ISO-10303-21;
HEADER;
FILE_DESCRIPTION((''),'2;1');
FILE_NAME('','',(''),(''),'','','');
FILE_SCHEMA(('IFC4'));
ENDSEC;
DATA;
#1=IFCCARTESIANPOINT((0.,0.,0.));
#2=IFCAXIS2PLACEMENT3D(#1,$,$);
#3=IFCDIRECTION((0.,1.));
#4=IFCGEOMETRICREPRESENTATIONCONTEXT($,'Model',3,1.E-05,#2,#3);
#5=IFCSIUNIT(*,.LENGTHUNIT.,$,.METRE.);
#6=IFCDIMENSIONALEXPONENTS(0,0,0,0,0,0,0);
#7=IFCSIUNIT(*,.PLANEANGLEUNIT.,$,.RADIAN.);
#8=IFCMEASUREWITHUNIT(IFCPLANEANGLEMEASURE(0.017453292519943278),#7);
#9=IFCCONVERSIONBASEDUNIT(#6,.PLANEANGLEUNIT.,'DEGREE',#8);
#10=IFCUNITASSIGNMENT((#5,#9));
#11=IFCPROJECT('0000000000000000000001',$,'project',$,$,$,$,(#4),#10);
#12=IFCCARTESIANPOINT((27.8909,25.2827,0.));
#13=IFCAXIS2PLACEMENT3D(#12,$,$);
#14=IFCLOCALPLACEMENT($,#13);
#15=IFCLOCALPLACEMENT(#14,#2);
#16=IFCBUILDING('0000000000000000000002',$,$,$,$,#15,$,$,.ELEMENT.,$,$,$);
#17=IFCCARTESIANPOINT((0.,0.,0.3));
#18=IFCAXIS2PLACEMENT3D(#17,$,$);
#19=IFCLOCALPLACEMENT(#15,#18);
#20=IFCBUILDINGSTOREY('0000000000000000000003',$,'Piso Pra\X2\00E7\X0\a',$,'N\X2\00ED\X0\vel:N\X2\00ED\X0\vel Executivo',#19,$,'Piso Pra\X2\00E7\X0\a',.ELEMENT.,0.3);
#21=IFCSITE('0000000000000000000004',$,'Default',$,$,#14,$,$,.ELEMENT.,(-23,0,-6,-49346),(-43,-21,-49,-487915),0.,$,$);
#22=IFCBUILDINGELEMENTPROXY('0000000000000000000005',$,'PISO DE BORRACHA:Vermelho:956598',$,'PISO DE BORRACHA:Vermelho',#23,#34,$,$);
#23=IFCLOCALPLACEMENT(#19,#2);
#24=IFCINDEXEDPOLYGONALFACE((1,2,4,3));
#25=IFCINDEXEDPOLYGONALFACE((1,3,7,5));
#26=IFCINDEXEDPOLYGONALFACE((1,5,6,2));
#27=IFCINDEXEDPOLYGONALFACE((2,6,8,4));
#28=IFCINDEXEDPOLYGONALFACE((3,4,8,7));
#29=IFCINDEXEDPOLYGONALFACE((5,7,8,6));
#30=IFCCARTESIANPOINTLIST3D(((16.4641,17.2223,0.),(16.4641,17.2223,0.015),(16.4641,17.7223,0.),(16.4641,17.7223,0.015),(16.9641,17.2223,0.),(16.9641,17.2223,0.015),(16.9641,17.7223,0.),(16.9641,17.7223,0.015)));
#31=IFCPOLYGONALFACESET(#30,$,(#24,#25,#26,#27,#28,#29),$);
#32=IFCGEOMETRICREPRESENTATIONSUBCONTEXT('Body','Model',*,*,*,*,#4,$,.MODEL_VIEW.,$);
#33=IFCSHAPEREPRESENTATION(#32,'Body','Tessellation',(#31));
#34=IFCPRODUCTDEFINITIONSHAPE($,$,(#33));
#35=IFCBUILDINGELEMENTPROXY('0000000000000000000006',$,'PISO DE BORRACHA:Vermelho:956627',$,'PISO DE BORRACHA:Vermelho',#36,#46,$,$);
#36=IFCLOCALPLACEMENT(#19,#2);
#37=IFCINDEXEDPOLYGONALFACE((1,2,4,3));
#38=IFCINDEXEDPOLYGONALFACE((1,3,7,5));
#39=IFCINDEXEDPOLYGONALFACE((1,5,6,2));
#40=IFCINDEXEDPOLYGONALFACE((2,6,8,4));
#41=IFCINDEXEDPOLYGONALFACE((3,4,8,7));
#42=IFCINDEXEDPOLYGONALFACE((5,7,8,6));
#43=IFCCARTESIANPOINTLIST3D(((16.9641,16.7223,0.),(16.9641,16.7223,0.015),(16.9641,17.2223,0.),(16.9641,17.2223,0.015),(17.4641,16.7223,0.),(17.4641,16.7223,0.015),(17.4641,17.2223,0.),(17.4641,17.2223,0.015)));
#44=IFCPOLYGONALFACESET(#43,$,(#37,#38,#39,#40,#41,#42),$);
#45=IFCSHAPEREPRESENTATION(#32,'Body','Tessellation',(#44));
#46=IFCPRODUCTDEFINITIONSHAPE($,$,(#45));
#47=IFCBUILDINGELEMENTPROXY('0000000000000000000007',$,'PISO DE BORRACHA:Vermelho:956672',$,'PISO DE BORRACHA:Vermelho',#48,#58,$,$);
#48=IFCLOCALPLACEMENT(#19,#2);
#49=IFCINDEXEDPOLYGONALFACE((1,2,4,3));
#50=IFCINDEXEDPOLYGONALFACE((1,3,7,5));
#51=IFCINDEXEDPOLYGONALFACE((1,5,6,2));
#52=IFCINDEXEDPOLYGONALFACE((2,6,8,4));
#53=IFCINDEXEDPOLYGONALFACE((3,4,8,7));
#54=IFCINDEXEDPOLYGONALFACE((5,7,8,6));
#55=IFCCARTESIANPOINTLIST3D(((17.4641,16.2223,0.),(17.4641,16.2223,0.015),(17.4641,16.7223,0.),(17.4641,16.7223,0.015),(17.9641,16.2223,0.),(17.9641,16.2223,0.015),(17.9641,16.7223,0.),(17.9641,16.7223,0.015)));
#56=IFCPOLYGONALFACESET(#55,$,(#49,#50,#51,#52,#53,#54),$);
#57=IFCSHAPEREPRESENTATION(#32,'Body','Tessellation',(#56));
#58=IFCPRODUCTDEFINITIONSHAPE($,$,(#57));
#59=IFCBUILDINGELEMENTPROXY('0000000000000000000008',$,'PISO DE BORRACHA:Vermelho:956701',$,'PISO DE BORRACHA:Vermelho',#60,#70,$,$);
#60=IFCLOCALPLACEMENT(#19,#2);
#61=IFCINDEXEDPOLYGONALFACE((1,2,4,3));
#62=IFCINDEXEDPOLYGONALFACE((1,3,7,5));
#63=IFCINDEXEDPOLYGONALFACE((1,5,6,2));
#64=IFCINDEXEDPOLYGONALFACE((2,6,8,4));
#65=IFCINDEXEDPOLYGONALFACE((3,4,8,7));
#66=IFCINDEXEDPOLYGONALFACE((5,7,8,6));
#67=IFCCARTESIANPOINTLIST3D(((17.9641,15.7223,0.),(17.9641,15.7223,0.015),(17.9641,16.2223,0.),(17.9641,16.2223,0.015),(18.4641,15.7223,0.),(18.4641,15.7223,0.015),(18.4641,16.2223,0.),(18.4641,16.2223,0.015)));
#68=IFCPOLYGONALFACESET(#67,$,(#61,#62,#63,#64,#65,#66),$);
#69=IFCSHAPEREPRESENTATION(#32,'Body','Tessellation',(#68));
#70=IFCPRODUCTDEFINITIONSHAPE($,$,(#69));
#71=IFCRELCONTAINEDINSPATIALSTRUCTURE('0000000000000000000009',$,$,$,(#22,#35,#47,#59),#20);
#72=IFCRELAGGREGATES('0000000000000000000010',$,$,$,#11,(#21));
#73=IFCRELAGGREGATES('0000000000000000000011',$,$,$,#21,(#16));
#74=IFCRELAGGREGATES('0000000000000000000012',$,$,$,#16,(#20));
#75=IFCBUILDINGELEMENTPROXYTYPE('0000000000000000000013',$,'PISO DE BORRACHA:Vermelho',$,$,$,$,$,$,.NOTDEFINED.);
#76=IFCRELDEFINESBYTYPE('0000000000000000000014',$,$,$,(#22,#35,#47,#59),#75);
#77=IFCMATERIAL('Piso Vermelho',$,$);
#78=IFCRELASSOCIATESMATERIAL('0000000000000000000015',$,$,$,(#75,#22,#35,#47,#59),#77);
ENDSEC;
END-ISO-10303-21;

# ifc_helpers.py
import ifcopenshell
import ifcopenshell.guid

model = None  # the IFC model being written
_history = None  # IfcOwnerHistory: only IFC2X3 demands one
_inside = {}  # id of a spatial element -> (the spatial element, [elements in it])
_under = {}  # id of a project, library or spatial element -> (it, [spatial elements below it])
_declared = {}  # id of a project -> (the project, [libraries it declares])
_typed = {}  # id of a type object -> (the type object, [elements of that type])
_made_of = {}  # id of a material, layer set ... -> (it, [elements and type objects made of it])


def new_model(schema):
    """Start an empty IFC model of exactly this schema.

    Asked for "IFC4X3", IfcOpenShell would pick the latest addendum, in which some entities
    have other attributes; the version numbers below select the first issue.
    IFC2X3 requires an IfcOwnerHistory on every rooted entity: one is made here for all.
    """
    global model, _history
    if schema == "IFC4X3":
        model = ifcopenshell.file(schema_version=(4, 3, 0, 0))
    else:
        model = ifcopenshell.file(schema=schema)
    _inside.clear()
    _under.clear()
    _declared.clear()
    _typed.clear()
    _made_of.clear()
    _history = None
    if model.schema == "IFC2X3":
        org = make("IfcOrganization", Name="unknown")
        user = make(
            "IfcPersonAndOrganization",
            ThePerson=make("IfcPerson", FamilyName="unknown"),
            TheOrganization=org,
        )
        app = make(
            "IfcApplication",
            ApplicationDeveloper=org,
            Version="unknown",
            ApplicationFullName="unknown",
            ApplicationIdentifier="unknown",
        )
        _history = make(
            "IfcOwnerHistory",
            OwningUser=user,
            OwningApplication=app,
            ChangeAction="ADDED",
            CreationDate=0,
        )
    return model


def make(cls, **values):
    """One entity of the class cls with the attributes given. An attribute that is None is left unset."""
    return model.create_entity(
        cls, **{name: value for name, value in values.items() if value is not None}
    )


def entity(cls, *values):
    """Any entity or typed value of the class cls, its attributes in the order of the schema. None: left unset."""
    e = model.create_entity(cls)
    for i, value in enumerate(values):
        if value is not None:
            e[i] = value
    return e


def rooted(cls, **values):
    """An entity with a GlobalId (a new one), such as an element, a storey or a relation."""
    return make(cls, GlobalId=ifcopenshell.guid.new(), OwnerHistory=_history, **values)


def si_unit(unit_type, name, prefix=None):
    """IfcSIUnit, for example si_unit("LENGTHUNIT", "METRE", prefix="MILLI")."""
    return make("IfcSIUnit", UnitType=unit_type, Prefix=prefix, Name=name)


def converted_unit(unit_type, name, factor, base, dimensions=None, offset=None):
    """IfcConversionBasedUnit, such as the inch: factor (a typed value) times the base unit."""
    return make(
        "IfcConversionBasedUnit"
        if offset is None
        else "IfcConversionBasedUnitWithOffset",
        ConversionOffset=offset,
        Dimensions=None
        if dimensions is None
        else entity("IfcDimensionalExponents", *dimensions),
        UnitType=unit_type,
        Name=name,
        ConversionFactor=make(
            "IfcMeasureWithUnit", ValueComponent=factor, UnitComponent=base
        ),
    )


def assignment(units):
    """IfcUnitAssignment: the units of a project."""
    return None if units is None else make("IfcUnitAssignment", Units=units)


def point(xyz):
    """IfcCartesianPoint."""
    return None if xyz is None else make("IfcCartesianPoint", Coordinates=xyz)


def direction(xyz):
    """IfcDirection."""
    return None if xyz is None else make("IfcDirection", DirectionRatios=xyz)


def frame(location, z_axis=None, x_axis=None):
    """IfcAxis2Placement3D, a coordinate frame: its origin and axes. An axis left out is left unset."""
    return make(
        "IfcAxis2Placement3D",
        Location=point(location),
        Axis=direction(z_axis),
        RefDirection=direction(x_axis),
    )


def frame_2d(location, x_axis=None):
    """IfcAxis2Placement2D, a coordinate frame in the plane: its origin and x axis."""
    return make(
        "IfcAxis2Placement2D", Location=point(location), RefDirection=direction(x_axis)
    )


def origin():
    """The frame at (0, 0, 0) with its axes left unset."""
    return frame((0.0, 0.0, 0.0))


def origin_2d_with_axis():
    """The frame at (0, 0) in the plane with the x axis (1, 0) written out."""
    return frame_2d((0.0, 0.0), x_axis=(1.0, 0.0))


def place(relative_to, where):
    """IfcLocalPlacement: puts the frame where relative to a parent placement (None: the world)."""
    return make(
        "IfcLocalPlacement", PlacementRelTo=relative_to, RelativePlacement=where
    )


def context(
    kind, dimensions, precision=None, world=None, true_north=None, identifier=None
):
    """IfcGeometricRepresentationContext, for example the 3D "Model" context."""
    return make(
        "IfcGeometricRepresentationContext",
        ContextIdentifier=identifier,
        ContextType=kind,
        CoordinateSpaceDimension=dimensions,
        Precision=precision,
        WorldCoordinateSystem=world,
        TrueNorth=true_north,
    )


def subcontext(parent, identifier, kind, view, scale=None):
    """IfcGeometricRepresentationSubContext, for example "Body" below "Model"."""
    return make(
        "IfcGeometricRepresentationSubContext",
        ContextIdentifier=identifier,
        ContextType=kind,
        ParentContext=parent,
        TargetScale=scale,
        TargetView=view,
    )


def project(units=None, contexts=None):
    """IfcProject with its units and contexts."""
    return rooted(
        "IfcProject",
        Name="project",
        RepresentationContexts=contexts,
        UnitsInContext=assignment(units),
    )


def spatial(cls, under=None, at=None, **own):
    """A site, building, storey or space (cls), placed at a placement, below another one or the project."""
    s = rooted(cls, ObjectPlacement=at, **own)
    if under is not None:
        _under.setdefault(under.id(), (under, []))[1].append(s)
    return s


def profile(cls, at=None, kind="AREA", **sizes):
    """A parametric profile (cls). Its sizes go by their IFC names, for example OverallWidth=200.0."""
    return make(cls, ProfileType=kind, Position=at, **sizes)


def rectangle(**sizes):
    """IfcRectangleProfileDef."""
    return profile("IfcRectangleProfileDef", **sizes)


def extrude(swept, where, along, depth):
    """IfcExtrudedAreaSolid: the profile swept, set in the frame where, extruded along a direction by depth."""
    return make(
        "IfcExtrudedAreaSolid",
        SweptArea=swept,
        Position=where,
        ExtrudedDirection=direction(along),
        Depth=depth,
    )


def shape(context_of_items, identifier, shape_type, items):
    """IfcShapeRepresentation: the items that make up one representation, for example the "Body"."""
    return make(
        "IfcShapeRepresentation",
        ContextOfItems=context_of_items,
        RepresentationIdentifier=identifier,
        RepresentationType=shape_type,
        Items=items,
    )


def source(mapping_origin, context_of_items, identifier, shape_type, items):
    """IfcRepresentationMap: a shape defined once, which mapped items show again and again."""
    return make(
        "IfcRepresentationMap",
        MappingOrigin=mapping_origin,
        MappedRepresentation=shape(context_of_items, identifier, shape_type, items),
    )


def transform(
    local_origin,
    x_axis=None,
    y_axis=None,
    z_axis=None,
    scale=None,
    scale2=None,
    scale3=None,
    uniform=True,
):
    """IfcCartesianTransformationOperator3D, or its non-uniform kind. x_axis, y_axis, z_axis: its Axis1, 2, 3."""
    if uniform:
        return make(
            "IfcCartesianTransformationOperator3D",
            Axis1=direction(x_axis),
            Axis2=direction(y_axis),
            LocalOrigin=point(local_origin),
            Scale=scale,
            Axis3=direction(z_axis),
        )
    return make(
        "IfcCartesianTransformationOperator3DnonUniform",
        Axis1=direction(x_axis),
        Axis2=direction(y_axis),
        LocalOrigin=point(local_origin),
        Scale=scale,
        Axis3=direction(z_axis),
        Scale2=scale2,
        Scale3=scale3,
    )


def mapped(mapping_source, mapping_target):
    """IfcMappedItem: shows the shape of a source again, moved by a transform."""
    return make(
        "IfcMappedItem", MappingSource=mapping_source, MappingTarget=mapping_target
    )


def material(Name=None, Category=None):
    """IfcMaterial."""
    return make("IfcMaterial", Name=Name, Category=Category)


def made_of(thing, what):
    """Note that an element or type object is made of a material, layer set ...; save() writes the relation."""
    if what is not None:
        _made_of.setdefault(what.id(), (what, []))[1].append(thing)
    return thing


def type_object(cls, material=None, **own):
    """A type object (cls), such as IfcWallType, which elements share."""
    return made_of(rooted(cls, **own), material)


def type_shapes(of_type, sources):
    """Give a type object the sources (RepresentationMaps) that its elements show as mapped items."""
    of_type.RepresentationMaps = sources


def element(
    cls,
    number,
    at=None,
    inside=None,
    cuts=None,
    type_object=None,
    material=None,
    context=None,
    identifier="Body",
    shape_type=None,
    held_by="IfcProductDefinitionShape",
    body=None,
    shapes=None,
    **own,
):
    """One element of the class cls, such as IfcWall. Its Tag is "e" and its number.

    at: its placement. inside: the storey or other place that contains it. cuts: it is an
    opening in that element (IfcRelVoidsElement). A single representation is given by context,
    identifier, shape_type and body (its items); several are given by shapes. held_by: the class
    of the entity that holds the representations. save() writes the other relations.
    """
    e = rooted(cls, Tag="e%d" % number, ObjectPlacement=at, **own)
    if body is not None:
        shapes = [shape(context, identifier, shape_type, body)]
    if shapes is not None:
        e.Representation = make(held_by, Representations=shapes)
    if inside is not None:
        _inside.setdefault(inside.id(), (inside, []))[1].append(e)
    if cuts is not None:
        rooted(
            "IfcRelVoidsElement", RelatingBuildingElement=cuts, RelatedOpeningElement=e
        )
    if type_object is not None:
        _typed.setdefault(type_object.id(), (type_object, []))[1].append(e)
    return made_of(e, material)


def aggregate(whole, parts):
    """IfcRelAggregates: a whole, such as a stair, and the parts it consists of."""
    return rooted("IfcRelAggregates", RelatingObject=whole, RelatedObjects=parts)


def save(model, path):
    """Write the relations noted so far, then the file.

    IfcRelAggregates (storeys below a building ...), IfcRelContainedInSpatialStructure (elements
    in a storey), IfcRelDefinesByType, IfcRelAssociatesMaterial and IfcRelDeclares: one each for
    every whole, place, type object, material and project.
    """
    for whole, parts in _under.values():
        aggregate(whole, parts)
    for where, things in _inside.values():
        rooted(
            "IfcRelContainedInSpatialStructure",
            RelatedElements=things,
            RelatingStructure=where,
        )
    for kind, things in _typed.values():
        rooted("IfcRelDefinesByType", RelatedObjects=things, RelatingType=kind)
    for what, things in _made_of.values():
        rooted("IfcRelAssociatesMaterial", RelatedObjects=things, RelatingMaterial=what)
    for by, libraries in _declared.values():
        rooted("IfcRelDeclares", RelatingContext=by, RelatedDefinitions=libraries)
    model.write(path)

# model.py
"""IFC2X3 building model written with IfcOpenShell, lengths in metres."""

from ifc_helpers import new_model, entity, si_unit, converted_unit, direction, frame, origin, origin_2d_with_axis, place, context, subcontext, project, spatial, rectangle, extrude, source, transform, mapped, material, type_object, type_shapes, element, save


model = new_model("IFC2X3")

# Units and contexts
model_context = context("Model", 3, precision=1e-05, world=origin(), true_north=direction((0.0, 1.0)))
body_context = subcontext(model_context, "Body", "Model", "MODEL_VIEW")
ifc_project = project(units=[si_unit("LENGTHUNIT", "METRE"), converted_unit("PLANEANGLEUNIT", "DEGREE", entity("IfcPlaneAngleMeasure", 0.017453292519943278), si_unit("PLANEANGLEUNIT", "RADIAN"), dimensions=[0, 0, 0, 0, 0, 0, 0])], contexts=[model_context])

# Site, building, storey
site_placement = place(None, frame((27.8909, 25.2827, 0.0)))
site = spatial("IfcSite", under=ifc_project, at=site_placement, Name="Default", CompositionType="ELEMENT", RefLatitude=(-23, 0, -6, -49346), RefLongitude=(-43, -21, -49, -487915), RefElevation=0.0)
building_placement = place(site_placement, origin())
building = spatial("IfcBuilding", under=site, at=building_placement, CompositionType="ELEMENT")
storey_placement = place(building_placement, frame((0.0, 0.0, 0.3)))
storey = spatial("IfcBuildingStorey", under=building, at=storey_placement, Name="Piso Praça", ObjectType="Nível:Nível Executivo", LongName="Piso Praça", CompositionType="ELEMENT", Elevation=0.3)

# Building element proxies
ifc_material_1 = material(Name="Piso Vermelho")
building_element_proxy_type_1 = type_object("IfcBuildingElementProxyType", Name="PISO DE BORRACHA:Vermelho", PredefinedType="NOTDEFINED", material=ifc_material_1)
shared_shape_1 = source(origin(), body_context, "Body", "SweptSolid", [
    extrude(rectangle(XDim=0.5, YDim=0.5, at=origin_2d_with_axis()), frame((0.25, 0.25, 0.0), z_axis=(0.0, 0.0, 1.0), x_axis=(-1.0, 0.0, 0.0)), (0.0, 0.0, 1.0), 0.015),
])
type_shapes(building_element_proxy_type_1, [shared_shape_1])
for number, where, name in (
    (1, (16.4641, 17.2223, 0.0), "PISO DE BORRACHA:Vermelho:956598"),
    (2, (16.9641, 16.7223, 0.0), "PISO DE BORRACHA:Vermelho:956627"),
    (3, (17.4641, 16.2223, 0.0), "PISO DE BORRACHA:Vermelho:956672"),
    (4, (17.9641, 15.7223, 0.0), "PISO DE BORRACHA:Vermelho:956701"),
):
    element("IfcBuildingElementProxy", number, at=place(storey_placement, frame(where)), inside=storey, type_object=building_element_proxy_type_1, material=ifc_material_1, Name=name, ObjectType="PISO DE BORRACHA:Vermelho", context=body_context, shape_type="MappedRepresentation", body=[
        mapped(shared_shape_1, transform((0.0, 0.0, 0.0), scale=1.0)),
    ])

save(model, "model.ifc")
